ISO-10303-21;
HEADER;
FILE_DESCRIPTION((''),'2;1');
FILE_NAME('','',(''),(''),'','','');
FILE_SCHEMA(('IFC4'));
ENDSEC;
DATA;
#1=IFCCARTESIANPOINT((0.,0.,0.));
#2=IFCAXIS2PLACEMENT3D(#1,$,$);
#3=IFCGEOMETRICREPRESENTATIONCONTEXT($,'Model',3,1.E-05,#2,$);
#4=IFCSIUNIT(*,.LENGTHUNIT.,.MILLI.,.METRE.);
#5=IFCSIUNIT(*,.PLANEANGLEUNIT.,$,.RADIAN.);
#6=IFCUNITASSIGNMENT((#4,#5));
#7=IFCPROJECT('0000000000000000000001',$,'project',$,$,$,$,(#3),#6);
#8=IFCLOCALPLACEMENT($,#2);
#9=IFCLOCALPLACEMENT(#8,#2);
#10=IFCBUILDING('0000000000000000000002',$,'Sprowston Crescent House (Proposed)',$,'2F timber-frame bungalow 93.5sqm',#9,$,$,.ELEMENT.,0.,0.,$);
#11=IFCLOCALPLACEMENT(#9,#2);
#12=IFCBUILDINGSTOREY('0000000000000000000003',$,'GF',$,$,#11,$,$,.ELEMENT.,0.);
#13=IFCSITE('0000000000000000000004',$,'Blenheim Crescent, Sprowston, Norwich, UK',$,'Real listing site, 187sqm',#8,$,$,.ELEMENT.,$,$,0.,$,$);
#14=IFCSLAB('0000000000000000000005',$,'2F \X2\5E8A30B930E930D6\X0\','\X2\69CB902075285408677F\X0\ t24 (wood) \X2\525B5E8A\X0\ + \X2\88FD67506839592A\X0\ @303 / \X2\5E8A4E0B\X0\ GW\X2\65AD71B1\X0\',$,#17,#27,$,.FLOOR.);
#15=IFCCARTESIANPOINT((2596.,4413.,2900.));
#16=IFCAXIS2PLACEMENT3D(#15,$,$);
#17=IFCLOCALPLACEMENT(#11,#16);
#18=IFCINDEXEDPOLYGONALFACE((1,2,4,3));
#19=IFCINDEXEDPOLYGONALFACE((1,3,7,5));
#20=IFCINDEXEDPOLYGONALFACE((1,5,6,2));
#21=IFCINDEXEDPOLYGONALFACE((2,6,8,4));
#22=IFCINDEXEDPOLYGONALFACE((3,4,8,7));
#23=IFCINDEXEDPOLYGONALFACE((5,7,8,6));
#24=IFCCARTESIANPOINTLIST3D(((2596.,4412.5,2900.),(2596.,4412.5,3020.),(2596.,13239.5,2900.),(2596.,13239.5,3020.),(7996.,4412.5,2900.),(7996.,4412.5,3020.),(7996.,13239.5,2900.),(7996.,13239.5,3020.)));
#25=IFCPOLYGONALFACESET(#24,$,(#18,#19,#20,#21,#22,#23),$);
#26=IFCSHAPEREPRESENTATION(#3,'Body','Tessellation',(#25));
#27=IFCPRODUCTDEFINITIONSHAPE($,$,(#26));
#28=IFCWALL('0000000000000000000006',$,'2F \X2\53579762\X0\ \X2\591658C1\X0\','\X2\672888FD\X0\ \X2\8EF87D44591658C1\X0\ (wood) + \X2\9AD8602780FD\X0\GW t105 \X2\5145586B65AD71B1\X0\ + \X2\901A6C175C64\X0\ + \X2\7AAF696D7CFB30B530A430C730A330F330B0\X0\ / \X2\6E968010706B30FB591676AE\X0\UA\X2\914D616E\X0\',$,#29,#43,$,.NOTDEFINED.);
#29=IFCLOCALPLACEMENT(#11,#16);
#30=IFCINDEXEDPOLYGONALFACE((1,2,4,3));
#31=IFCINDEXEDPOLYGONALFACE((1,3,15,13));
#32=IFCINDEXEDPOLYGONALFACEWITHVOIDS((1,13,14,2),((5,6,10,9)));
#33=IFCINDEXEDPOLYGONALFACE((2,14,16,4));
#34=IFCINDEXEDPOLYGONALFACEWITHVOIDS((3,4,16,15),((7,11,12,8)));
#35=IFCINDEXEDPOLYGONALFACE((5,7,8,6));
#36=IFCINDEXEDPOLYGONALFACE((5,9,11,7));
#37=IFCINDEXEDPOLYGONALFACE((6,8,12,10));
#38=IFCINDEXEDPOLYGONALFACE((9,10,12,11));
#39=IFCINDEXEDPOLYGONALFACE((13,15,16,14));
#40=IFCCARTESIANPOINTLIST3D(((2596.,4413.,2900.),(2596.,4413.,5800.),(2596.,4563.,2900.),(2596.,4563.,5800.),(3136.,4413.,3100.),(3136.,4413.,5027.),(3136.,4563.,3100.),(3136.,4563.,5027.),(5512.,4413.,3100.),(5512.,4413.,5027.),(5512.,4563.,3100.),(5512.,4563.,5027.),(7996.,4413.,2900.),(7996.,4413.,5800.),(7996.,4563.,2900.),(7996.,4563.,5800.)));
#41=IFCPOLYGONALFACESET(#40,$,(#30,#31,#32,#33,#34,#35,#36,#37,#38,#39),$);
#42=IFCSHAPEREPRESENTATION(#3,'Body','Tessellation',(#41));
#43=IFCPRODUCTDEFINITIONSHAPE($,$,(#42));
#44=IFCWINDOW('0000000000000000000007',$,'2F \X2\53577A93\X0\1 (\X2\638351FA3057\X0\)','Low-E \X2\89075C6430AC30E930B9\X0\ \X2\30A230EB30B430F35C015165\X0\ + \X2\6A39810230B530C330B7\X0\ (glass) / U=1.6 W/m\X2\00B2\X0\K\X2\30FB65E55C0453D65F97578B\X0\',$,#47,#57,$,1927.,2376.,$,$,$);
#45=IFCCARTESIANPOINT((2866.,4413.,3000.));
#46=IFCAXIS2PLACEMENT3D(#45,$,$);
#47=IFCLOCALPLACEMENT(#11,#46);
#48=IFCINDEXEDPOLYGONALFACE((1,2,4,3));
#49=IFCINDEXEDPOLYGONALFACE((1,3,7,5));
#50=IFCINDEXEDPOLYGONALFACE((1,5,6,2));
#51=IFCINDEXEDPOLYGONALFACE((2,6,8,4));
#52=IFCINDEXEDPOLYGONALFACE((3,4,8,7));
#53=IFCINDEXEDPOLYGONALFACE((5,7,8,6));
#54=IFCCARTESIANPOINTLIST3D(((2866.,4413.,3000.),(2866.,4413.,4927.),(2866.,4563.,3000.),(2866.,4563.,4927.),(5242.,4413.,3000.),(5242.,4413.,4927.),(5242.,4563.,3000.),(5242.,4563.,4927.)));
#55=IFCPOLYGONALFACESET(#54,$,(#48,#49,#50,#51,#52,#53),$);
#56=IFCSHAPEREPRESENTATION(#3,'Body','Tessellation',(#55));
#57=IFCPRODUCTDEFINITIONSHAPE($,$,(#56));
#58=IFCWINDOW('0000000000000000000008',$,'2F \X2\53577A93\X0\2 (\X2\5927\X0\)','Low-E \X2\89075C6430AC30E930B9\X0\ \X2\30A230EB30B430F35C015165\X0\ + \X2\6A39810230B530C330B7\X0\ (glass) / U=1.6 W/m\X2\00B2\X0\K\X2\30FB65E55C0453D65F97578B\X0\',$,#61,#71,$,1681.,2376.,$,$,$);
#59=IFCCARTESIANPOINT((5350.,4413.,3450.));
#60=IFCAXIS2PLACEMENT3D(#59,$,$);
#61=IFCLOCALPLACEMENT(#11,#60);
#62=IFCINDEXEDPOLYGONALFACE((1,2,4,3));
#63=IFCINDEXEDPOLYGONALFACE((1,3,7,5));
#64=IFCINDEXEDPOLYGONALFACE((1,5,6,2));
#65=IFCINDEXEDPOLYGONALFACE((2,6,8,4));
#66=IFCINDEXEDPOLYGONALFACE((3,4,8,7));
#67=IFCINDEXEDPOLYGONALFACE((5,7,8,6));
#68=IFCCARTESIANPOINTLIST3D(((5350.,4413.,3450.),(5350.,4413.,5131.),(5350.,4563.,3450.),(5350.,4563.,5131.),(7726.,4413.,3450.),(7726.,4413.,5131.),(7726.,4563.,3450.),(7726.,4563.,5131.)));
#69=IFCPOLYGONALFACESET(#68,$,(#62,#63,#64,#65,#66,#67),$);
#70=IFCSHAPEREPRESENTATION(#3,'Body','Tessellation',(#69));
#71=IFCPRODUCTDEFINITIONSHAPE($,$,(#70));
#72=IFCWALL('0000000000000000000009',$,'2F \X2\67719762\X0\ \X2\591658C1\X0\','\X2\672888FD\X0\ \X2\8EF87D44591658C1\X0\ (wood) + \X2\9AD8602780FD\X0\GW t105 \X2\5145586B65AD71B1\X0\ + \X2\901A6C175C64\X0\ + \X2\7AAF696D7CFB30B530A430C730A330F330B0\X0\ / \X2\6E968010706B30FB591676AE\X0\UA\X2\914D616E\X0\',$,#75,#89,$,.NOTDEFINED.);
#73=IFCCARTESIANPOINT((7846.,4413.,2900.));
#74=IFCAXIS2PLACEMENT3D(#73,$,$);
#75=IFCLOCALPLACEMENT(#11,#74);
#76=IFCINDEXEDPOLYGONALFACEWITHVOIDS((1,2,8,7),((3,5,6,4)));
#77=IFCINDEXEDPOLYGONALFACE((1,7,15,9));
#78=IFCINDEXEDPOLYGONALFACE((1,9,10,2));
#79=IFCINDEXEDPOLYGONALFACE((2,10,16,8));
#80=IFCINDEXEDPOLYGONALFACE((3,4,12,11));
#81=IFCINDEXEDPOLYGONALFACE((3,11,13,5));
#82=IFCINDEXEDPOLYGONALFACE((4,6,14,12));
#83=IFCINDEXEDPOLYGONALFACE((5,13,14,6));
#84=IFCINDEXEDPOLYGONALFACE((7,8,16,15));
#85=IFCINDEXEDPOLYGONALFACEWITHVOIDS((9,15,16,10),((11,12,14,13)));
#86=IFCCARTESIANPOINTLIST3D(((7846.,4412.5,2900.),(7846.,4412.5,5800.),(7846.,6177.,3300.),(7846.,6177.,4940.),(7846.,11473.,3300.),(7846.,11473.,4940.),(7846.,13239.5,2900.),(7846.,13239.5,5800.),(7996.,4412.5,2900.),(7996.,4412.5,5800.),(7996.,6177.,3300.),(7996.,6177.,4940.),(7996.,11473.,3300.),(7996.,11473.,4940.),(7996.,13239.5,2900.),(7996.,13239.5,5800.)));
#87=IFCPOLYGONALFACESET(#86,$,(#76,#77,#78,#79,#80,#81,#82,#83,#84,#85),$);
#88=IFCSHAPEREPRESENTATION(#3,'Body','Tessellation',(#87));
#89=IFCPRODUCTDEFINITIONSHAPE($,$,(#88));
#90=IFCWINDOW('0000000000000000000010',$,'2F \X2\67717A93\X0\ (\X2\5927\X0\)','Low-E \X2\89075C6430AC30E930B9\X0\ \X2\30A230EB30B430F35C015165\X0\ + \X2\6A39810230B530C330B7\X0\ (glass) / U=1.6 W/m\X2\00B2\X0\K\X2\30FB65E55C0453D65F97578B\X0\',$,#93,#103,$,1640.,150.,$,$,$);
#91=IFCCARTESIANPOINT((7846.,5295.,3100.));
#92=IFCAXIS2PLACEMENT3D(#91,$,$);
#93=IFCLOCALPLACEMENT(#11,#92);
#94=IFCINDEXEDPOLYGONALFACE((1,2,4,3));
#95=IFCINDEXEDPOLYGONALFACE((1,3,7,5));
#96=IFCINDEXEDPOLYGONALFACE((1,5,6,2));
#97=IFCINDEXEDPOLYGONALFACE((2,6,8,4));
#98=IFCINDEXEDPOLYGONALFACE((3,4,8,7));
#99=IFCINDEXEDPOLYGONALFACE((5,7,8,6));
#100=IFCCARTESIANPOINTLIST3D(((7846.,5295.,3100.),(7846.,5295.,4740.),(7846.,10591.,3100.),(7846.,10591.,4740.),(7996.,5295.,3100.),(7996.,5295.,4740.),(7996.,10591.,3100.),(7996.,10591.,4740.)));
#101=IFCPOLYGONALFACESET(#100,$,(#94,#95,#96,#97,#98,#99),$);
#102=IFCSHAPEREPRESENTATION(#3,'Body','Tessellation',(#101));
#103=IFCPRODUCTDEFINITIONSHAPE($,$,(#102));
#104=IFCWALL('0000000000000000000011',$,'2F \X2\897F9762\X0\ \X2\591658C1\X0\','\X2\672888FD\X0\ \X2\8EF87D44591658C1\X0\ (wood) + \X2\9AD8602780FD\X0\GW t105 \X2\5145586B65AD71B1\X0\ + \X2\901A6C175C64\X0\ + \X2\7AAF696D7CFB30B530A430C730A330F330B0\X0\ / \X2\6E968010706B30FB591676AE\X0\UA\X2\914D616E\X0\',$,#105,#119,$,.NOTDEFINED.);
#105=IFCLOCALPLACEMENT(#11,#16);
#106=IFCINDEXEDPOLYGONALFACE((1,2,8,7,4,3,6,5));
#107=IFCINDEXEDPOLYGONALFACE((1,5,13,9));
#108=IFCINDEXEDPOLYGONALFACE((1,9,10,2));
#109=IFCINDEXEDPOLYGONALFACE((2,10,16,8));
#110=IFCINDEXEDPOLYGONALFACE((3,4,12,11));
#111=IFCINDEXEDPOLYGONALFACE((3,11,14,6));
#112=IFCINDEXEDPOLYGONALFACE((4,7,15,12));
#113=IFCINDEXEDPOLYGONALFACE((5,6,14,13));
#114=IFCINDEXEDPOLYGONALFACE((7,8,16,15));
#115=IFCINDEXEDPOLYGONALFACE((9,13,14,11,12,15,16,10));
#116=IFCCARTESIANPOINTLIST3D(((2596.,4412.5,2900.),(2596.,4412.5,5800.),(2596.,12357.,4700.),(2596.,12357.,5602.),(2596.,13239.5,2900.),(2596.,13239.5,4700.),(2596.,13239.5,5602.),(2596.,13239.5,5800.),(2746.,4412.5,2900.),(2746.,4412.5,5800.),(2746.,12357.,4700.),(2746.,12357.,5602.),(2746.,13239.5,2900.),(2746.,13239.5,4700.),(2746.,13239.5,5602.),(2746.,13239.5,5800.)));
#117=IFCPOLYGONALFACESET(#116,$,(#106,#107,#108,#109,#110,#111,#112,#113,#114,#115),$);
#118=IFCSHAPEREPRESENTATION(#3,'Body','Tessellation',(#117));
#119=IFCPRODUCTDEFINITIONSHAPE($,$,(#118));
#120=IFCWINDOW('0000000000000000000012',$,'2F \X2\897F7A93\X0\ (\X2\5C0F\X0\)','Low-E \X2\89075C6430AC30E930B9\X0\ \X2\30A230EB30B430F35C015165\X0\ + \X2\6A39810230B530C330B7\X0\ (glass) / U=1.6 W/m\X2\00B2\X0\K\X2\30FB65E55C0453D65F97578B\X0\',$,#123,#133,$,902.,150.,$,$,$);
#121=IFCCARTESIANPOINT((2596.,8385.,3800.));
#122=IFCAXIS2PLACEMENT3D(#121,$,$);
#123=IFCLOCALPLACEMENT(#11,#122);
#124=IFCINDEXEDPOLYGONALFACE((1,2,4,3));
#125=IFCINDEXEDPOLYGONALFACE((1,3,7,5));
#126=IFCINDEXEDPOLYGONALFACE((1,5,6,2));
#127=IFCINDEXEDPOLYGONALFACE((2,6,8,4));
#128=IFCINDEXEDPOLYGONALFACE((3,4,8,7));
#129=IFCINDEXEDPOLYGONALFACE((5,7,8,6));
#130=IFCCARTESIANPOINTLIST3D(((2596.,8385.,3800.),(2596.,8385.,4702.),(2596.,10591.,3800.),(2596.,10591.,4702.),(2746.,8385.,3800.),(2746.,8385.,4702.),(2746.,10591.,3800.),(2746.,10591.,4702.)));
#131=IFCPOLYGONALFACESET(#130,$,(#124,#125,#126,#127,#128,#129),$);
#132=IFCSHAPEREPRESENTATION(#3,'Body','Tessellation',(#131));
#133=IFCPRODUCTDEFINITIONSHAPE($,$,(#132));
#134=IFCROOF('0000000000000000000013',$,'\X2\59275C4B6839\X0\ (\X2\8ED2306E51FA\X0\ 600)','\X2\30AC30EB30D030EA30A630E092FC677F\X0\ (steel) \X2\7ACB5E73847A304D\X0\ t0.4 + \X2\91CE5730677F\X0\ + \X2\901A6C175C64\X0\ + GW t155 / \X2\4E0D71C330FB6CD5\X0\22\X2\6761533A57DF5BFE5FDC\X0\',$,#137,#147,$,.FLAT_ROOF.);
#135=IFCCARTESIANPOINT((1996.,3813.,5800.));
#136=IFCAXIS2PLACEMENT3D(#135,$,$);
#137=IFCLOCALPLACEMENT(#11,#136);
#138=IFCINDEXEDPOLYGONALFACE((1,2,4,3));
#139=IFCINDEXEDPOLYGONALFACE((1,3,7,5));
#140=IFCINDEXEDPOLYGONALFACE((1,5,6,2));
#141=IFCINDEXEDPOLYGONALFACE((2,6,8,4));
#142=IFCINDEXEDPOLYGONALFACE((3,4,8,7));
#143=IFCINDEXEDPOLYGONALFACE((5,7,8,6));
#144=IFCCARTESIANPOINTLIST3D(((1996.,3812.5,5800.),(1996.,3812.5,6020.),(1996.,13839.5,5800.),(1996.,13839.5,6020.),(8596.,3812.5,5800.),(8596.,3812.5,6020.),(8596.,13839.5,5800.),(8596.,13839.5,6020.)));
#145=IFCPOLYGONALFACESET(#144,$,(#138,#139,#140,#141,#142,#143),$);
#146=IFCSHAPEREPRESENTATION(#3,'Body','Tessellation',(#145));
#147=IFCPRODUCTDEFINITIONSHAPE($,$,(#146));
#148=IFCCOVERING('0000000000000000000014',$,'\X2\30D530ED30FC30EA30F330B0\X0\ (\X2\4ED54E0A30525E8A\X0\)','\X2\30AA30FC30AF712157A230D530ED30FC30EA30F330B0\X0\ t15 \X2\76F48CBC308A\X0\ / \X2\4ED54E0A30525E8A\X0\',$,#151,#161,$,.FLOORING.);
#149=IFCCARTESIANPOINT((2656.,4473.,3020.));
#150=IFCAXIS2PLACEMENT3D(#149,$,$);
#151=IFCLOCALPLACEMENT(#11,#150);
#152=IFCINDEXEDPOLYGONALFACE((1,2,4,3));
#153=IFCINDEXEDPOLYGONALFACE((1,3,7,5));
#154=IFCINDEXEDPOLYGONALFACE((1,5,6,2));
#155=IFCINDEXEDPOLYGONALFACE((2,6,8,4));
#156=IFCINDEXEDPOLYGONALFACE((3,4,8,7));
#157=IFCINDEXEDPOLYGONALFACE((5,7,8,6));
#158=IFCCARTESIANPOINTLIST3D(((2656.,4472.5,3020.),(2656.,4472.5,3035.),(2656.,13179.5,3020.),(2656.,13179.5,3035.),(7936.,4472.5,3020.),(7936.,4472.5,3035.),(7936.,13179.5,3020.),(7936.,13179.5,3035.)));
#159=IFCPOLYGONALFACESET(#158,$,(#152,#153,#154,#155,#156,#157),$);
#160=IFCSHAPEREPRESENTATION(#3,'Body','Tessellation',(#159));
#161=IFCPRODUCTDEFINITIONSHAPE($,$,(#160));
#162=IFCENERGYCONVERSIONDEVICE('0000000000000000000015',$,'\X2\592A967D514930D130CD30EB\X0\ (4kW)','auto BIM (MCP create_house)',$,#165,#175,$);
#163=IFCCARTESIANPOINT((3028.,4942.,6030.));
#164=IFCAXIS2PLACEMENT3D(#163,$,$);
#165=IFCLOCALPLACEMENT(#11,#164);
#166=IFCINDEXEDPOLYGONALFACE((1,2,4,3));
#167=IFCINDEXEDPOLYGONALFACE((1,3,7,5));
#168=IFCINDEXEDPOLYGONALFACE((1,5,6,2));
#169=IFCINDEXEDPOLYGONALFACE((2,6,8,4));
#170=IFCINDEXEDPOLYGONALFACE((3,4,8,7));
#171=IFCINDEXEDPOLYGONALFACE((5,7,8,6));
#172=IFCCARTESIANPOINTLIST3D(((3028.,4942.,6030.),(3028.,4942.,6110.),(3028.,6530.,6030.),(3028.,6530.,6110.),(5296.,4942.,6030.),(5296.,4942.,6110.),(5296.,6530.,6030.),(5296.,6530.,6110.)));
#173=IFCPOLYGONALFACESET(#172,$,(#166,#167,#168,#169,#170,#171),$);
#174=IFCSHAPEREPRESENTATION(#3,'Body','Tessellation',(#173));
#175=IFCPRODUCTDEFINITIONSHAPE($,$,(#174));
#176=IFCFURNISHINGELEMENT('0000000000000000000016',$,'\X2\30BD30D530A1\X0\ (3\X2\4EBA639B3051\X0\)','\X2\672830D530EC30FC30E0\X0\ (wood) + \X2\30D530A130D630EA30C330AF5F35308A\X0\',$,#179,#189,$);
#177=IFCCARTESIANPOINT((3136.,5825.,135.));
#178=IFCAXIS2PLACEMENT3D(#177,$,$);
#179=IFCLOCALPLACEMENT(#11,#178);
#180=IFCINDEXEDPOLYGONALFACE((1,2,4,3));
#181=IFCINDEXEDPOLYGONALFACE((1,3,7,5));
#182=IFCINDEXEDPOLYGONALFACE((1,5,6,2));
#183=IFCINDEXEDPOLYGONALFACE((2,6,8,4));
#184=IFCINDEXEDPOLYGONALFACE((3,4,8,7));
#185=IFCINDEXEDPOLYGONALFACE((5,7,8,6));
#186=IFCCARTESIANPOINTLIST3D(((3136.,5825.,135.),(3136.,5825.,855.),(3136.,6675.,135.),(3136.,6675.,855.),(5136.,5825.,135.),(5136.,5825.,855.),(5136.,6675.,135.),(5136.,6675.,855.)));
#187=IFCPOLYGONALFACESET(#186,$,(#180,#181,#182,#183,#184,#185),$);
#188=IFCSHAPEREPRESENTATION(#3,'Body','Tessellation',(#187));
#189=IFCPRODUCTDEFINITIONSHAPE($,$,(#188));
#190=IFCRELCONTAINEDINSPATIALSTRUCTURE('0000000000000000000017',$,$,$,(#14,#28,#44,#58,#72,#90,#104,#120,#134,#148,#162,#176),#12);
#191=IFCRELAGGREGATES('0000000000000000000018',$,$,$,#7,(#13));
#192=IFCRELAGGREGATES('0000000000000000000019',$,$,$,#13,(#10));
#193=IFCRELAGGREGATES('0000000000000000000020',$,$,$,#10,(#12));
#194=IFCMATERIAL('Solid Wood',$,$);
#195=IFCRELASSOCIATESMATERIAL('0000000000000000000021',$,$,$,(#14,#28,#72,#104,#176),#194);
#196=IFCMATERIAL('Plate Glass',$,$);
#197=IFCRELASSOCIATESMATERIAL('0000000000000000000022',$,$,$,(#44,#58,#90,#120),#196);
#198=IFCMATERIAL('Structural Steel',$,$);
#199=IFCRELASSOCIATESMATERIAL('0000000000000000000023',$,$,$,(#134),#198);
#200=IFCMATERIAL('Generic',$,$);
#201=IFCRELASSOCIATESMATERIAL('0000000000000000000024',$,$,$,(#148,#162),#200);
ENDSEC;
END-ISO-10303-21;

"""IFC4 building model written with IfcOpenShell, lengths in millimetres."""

from ifc_helpers import new_model, si_unit, frame, frame_2d, origin, place, context, project, spatial, rectangle, extrude, material, element, fill, save


model = new_model("IFC4")

# Units and contexts
model_context = context("Model", 3, precision=1e-05, world=origin())
ifc_project = project(units=[si_unit("LENGTHUNIT", "METRE", prefix="MILLI"), si_unit("PLANEANGLEUNIT", "RADIAN")], contexts=[model_context])

# Site, building, storey
site_placement = place(None, origin())
site = spatial("IfcSite", under=ifc_project, at=site_placement, Name="Blenheim Crescent, Sprowston, Norwich, UK", ObjectType="Real listing site, 187sqm", CompositionType="ELEMENT", RefElevation=0.0)
building_placement = place(site_placement, origin())
building = spatial("IfcBuilding", under=site, at=building_placement, Name="Sprowston Crescent House (Proposed)", ObjectType="2F timber-frame bungalow 93.5sqm", CompositionType="ELEMENT", ElevationOfRefHeight=0.0, ElevationOfTerrain=0.0)
storey_placement = place(building_placement, origin())
storey = spatial("IfcBuildingStorey", under=building, at=storey_placement, Name="GF", CompositionType="ELEMENT", Elevation=0.0)

# Slab
ifc_material_1 = material(Name="Solid Wood")
slab_placement = place(storey_placement, frame((2596.0, 4413.0, 2900.0)))
element("IfcSlab", 1, at=slab_placement, inside=storey, material=ifc_material_1, Name="2F 床スラブ", Description="構造用合板 t24 (wood) 剛床 + 製材根太 @303 / 床下 GW断熱", PredefinedType="FLOOR", context=model_context, shape_type="SweptSolid", body=[
    extrude(rectangle(XDim=5400.0, YDim=8827.0, at=frame_2d((2700.0, 4413.0))), frame((2596.0, 4413.0, 2900.0)), (0.0, 0.0, 1.0), 120.0),
])

# Wall, openings, windows
wall_1_placement = place(storey_placement, frame((2596.0, 4413.0, 2900.0)))
wall_1 = element("IfcWall", 2, at=wall_1_placement, inside=storey, material=ifc_material_1, Name="2F 南面 外壁", Description="木製 軸組外壁 (wood) + 高性能GW t105 充填断熱 + 通気層 + 窯業系サイディング / 準耐火・外皮UA配慮", PredefinedType="NOTDEFINED", context=model_context, shape_type="SweptSolid", body=[
    extrude(rectangle(XDim=5400.0, YDim=150.0, at=frame_2d((2700.0, 75.0))), frame((2596.0, 4413.0, 2900.0)), (0.0, 0.0, 1.0), 2900.0),
])
opening_1_placement = place(storey_placement, frame((2866.0, 4413.0, 3000.0)))
opening_1 = element("IfcOpeningElement", 3, at=opening_1_placement, cuts=wall_1, PredefinedType="NOTDEFINED", context=model_context, shape_type="SweptSolid", body=[
    extrude(rectangle(XDim=2376.0, YDim=150.0, at=frame_2d((1188.0, 75.0))), frame((2866.0, 4413.0, 3000.0)), (0.0, 0.0, 1.0), 1927.0),
])
opening_2_placement = place(storey_placement, frame((5350.0, 4413.0, 3450.0)))
opening_2 = element("IfcOpeningElement", 4, at=opening_2_placement, cuts=wall_1, PredefinedType="NOTDEFINED", context=model_context, shape_type="SweptSolid", body=[
    extrude(rectangle(XDim=2376.0, YDim=150.0, at=frame_2d((1188.0, 75.0))), frame((5350.0, 4413.0, 3450.0)), (0.0, 0.0, 1.0), 1681.0),
])
ifc_material_2 = material(Name="Plate Glass")
window_1_placement = place(storey_placement, frame((2866.0, 4413.0, 3000.0)))
window_1 = element("IfcWindow", 5, at=window_1_placement, inside=storey, material=ifc_material_2, Name="2F 南窓1 (掃出し)", Description="Low-E 複層ガラス アルゴン封入 + 樹脂サッシ (glass) / U=1.6 W/m²K・日射取得型", OverallHeight=1927.0, OverallWidth=2376.0, context=model_context, shape_type="SweptSolid", body=[
    extrude(rectangle(XDim=2376.0, YDim=150.0, at=frame_2d((1188.0, 75.0))), frame((2866.0, 4413.0, 3000.0)), (0.0, 0.0, 1.0), 1927.0),
])
fill(opening_1, window_1)
window_2_placement = place(storey_placement, frame((5350.0, 4413.0, 3450.0)))
window_2 = element("IfcWindow", 6, at=window_2_placement, inside=storey, material=ifc_material_2, Name="2F 南窓2 (大)", Description="Low-E 複層ガラス アルゴン封入 + 樹脂サッシ (glass) / U=1.6 W/m²K・日射取得型", OverallHeight=1681.0, OverallWidth=2376.0, context=model_context, shape_type="SweptSolid", body=[
    extrude(rectangle(XDim=2376.0, YDim=150.0, at=frame_2d((1188.0, 75.0))), frame((5350.0, 4413.0, 3450.0)), (0.0, 0.0, 1.0), 1681.0),
])
fill(opening_2, window_2)

# Walls, openings, windows
wall_2_placement = place(storey_placement, frame((7846.0, 4413.0, 2900.0)))
wall_2 = element("IfcWall", 7, at=wall_2_placement, inside=storey, material=ifc_material_1, Name="2F 東面 外壁", Description="木製 軸組外壁 (wood) + 高性能GW t105 充填断熱 + 通気層 + 窯業系サイディング / 準耐火・外皮UA配慮", PredefinedType="NOTDEFINED", context=model_context, shape_type="SweptSolid", body=[
    extrude(rectangle(XDim=150.0, YDim=8827.0, at=frame_2d((75.0, 4413.0))), frame((7846.0, 4413.0, 2900.0)), (0.0, 0.0, 1.0), 2900.0),
])
opening_3_placement = place(storey_placement, frame((7846.0, 5295.0, 3100.0)))
opening_3 = element("IfcOpeningElement", 8, at=opening_3_placement, cuts=wall_2, PredefinedType="NOTDEFINED", context=model_context, shape_type="SweptSolid", body=[
    extrude(rectangle(XDim=150.0, YDim=5296.0, at=frame_2d((75.0, 2648.0))), frame((7846.0, 5295.0, 3100.0)), (0.0, 0.0, 1.0), 1640.0),
])
window_3_placement = place(storey_placement, frame((7846.0, 5295.0, 3100.0)))
window_3 = element("IfcWindow", 9, at=window_3_placement, inside=storey, material=ifc_material_2, Name="2F 東窓 (大)", Description="Low-E 複層ガラス アルゴン封入 + 樹脂サッシ (glass) / U=1.6 W/m²K・日射取得型", OverallHeight=1640.0, OverallWidth=150.0, context=model_context, shape_type="SweptSolid", body=[
    extrude(rectangle(XDim=150.0, YDim=5296.0, at=frame_2d((75.0, 2648.0))), frame((7846.0, 5295.0, 3100.0)), (0.0, 0.0, 1.0), 1640.0),
])
fill(opening_3, window_3)
wall_3_placement = place(storey_placement, frame((2596.0, 4413.0, 2900.0)))
wall_3 = element("IfcWall", 10, at=wall_3_placement, inside=storey, material=ifc_material_1, Name="2F 西面 外壁", Description="木製 軸組外壁 (wood) + 高性能GW t105 充填断熱 + 通気層 + 窯業系サイディング / 準耐火・外皮UA配慮", PredefinedType="NOTDEFINED", context=model_context, shape_type="SweptSolid", body=[
    extrude(rectangle(XDim=150.0, YDim=8827.0, at=frame_2d((75.0, 4413.0))), frame((2596.0, 4413.0, 2900.0)), (0.0, 0.0, 1.0), 2900.0),
])
opening_4_placement = place(storey_placement, frame((2596.0, 8385.0, 3800.0)))
opening_4 = element("IfcOpeningElement", 11, at=opening_4_placement, cuts=wall_3, PredefinedType="NOTDEFINED", context=model_context, shape_type="SweptSolid", body=[
    extrude(rectangle(XDim=150.0, YDim=2206.0, at=frame_2d((75.0, 1103.0))), frame((2596.0, 8385.0, 3800.0)), (0.0, 0.0, 1.0), 902.0),
])
window_4_placement = place(storey_placement, frame((2596.0, 8385.0, 3800.0)))
window_4 = element("IfcWindow", 12, at=window_4_placement, inside=storey, material=ifc_material_2, Name="2F 西窓 (小)", Description="Low-E 複層ガラス アルゴン封入 + 樹脂サッシ (glass) / U=1.6 W/m²K・日射取得型", OverallHeight=902.0, OverallWidth=150.0, context=model_context, shape_type="SweptSolid", body=[
    extrude(rectangle(XDim=150.0, YDim=2206.0, at=frame_2d((75.0, 1103.0))), frame((2596.0, 8385.0, 3800.0)), (0.0, 0.0, 1.0), 902.0),
])
fill(opening_4, window_4)

# Roof
ifc_material_3 = material(Name="Structural Steel")
roof_placement = place(storey_placement, frame((1996.0, 3813.0, 5800.0)))
element("IfcRoof", 13, at=roof_placement, inside=storey, material=ifc_material_3, Name="大屋根 (軒の出 600)", Description="ガルバリウム鋼板 (steel) 立平葺き t0.4 + 野地板 + 通気層 + GW t155 / 不燃・法22条区域対応", PredefinedType="FLAT_ROOF", context=model_context, shape_type="SweptSolid", body=[
    extrude(rectangle(XDim=6600.0, YDim=10027.0, at=frame_2d((3300.0, 5013.0))), frame((1996.0, 3813.0, 5800.0)), (0.0, 0.0, 1.0), 220.0),
])

# Covering
ifc_material_4 = material(Name="Generic")
covering_placement = place(storey_placement, frame((2656.0, 4473.0, 3020.0)))
element("IfcCovering", 14, at=covering_placement, inside=storey, material=ifc_material_4, Name="フローリング (仕上げ床)", Description="オーク無垢フローリング t15 直貼り / 仕上げ床", PredefinedType="FLOORING", context=model_context, shape_type="SweptSolid", body=[
    extrude(rectangle(XDim=5280.0, YDim=8707.0, at=frame_2d((2640.0, 4353.0))), frame((2656.0, 4473.0, 3020.0)), (0.0, 0.0, 1.0), 15.0),
])

# Energy conversion device
energy_conversion_device_placement = place(storey_placement, frame((3028.0, 4942.0, 6030.0)))
element("IfcEnergyConversionDevice", 15, at=energy_conversion_device_placement, inside=storey, material=ifc_material_4, Name="太陽光パネル (4kW)", Description="auto BIM (MCP create_house)", context=model_context, shape_type="SweptSolid", body=[
    extrude(rectangle(XDim=2268.0, YDim=1588.0, at=frame_2d((1134.0, 794.0))), frame((3028.0, 4942.0, 6030.0)), (0.0, 0.0, 1.0), 80.0),
])

# Furnishing element
furnishing_1_placement = place(storey_placement, frame((3136.0, 5825.0, 135.0)))
element("IfcFurnishingElement", 16, at=furnishing_1_placement, inside=storey, material=ifc_material_1, Name="ソファ (3人掛け)", Description="木フレーム (wood) + ファブリック張り", context=model_context, shape_type="SweptSolid", body=[
    extrude(rectangle(XDim=2000.0, YDim=850.0, at=frame_2d((1000.0, 425.0))), frame((3136.0, 5825.0, 135.0)), (0.0, 0.0, 1.0), 720.0),
])

save(model, "model.ifc")
